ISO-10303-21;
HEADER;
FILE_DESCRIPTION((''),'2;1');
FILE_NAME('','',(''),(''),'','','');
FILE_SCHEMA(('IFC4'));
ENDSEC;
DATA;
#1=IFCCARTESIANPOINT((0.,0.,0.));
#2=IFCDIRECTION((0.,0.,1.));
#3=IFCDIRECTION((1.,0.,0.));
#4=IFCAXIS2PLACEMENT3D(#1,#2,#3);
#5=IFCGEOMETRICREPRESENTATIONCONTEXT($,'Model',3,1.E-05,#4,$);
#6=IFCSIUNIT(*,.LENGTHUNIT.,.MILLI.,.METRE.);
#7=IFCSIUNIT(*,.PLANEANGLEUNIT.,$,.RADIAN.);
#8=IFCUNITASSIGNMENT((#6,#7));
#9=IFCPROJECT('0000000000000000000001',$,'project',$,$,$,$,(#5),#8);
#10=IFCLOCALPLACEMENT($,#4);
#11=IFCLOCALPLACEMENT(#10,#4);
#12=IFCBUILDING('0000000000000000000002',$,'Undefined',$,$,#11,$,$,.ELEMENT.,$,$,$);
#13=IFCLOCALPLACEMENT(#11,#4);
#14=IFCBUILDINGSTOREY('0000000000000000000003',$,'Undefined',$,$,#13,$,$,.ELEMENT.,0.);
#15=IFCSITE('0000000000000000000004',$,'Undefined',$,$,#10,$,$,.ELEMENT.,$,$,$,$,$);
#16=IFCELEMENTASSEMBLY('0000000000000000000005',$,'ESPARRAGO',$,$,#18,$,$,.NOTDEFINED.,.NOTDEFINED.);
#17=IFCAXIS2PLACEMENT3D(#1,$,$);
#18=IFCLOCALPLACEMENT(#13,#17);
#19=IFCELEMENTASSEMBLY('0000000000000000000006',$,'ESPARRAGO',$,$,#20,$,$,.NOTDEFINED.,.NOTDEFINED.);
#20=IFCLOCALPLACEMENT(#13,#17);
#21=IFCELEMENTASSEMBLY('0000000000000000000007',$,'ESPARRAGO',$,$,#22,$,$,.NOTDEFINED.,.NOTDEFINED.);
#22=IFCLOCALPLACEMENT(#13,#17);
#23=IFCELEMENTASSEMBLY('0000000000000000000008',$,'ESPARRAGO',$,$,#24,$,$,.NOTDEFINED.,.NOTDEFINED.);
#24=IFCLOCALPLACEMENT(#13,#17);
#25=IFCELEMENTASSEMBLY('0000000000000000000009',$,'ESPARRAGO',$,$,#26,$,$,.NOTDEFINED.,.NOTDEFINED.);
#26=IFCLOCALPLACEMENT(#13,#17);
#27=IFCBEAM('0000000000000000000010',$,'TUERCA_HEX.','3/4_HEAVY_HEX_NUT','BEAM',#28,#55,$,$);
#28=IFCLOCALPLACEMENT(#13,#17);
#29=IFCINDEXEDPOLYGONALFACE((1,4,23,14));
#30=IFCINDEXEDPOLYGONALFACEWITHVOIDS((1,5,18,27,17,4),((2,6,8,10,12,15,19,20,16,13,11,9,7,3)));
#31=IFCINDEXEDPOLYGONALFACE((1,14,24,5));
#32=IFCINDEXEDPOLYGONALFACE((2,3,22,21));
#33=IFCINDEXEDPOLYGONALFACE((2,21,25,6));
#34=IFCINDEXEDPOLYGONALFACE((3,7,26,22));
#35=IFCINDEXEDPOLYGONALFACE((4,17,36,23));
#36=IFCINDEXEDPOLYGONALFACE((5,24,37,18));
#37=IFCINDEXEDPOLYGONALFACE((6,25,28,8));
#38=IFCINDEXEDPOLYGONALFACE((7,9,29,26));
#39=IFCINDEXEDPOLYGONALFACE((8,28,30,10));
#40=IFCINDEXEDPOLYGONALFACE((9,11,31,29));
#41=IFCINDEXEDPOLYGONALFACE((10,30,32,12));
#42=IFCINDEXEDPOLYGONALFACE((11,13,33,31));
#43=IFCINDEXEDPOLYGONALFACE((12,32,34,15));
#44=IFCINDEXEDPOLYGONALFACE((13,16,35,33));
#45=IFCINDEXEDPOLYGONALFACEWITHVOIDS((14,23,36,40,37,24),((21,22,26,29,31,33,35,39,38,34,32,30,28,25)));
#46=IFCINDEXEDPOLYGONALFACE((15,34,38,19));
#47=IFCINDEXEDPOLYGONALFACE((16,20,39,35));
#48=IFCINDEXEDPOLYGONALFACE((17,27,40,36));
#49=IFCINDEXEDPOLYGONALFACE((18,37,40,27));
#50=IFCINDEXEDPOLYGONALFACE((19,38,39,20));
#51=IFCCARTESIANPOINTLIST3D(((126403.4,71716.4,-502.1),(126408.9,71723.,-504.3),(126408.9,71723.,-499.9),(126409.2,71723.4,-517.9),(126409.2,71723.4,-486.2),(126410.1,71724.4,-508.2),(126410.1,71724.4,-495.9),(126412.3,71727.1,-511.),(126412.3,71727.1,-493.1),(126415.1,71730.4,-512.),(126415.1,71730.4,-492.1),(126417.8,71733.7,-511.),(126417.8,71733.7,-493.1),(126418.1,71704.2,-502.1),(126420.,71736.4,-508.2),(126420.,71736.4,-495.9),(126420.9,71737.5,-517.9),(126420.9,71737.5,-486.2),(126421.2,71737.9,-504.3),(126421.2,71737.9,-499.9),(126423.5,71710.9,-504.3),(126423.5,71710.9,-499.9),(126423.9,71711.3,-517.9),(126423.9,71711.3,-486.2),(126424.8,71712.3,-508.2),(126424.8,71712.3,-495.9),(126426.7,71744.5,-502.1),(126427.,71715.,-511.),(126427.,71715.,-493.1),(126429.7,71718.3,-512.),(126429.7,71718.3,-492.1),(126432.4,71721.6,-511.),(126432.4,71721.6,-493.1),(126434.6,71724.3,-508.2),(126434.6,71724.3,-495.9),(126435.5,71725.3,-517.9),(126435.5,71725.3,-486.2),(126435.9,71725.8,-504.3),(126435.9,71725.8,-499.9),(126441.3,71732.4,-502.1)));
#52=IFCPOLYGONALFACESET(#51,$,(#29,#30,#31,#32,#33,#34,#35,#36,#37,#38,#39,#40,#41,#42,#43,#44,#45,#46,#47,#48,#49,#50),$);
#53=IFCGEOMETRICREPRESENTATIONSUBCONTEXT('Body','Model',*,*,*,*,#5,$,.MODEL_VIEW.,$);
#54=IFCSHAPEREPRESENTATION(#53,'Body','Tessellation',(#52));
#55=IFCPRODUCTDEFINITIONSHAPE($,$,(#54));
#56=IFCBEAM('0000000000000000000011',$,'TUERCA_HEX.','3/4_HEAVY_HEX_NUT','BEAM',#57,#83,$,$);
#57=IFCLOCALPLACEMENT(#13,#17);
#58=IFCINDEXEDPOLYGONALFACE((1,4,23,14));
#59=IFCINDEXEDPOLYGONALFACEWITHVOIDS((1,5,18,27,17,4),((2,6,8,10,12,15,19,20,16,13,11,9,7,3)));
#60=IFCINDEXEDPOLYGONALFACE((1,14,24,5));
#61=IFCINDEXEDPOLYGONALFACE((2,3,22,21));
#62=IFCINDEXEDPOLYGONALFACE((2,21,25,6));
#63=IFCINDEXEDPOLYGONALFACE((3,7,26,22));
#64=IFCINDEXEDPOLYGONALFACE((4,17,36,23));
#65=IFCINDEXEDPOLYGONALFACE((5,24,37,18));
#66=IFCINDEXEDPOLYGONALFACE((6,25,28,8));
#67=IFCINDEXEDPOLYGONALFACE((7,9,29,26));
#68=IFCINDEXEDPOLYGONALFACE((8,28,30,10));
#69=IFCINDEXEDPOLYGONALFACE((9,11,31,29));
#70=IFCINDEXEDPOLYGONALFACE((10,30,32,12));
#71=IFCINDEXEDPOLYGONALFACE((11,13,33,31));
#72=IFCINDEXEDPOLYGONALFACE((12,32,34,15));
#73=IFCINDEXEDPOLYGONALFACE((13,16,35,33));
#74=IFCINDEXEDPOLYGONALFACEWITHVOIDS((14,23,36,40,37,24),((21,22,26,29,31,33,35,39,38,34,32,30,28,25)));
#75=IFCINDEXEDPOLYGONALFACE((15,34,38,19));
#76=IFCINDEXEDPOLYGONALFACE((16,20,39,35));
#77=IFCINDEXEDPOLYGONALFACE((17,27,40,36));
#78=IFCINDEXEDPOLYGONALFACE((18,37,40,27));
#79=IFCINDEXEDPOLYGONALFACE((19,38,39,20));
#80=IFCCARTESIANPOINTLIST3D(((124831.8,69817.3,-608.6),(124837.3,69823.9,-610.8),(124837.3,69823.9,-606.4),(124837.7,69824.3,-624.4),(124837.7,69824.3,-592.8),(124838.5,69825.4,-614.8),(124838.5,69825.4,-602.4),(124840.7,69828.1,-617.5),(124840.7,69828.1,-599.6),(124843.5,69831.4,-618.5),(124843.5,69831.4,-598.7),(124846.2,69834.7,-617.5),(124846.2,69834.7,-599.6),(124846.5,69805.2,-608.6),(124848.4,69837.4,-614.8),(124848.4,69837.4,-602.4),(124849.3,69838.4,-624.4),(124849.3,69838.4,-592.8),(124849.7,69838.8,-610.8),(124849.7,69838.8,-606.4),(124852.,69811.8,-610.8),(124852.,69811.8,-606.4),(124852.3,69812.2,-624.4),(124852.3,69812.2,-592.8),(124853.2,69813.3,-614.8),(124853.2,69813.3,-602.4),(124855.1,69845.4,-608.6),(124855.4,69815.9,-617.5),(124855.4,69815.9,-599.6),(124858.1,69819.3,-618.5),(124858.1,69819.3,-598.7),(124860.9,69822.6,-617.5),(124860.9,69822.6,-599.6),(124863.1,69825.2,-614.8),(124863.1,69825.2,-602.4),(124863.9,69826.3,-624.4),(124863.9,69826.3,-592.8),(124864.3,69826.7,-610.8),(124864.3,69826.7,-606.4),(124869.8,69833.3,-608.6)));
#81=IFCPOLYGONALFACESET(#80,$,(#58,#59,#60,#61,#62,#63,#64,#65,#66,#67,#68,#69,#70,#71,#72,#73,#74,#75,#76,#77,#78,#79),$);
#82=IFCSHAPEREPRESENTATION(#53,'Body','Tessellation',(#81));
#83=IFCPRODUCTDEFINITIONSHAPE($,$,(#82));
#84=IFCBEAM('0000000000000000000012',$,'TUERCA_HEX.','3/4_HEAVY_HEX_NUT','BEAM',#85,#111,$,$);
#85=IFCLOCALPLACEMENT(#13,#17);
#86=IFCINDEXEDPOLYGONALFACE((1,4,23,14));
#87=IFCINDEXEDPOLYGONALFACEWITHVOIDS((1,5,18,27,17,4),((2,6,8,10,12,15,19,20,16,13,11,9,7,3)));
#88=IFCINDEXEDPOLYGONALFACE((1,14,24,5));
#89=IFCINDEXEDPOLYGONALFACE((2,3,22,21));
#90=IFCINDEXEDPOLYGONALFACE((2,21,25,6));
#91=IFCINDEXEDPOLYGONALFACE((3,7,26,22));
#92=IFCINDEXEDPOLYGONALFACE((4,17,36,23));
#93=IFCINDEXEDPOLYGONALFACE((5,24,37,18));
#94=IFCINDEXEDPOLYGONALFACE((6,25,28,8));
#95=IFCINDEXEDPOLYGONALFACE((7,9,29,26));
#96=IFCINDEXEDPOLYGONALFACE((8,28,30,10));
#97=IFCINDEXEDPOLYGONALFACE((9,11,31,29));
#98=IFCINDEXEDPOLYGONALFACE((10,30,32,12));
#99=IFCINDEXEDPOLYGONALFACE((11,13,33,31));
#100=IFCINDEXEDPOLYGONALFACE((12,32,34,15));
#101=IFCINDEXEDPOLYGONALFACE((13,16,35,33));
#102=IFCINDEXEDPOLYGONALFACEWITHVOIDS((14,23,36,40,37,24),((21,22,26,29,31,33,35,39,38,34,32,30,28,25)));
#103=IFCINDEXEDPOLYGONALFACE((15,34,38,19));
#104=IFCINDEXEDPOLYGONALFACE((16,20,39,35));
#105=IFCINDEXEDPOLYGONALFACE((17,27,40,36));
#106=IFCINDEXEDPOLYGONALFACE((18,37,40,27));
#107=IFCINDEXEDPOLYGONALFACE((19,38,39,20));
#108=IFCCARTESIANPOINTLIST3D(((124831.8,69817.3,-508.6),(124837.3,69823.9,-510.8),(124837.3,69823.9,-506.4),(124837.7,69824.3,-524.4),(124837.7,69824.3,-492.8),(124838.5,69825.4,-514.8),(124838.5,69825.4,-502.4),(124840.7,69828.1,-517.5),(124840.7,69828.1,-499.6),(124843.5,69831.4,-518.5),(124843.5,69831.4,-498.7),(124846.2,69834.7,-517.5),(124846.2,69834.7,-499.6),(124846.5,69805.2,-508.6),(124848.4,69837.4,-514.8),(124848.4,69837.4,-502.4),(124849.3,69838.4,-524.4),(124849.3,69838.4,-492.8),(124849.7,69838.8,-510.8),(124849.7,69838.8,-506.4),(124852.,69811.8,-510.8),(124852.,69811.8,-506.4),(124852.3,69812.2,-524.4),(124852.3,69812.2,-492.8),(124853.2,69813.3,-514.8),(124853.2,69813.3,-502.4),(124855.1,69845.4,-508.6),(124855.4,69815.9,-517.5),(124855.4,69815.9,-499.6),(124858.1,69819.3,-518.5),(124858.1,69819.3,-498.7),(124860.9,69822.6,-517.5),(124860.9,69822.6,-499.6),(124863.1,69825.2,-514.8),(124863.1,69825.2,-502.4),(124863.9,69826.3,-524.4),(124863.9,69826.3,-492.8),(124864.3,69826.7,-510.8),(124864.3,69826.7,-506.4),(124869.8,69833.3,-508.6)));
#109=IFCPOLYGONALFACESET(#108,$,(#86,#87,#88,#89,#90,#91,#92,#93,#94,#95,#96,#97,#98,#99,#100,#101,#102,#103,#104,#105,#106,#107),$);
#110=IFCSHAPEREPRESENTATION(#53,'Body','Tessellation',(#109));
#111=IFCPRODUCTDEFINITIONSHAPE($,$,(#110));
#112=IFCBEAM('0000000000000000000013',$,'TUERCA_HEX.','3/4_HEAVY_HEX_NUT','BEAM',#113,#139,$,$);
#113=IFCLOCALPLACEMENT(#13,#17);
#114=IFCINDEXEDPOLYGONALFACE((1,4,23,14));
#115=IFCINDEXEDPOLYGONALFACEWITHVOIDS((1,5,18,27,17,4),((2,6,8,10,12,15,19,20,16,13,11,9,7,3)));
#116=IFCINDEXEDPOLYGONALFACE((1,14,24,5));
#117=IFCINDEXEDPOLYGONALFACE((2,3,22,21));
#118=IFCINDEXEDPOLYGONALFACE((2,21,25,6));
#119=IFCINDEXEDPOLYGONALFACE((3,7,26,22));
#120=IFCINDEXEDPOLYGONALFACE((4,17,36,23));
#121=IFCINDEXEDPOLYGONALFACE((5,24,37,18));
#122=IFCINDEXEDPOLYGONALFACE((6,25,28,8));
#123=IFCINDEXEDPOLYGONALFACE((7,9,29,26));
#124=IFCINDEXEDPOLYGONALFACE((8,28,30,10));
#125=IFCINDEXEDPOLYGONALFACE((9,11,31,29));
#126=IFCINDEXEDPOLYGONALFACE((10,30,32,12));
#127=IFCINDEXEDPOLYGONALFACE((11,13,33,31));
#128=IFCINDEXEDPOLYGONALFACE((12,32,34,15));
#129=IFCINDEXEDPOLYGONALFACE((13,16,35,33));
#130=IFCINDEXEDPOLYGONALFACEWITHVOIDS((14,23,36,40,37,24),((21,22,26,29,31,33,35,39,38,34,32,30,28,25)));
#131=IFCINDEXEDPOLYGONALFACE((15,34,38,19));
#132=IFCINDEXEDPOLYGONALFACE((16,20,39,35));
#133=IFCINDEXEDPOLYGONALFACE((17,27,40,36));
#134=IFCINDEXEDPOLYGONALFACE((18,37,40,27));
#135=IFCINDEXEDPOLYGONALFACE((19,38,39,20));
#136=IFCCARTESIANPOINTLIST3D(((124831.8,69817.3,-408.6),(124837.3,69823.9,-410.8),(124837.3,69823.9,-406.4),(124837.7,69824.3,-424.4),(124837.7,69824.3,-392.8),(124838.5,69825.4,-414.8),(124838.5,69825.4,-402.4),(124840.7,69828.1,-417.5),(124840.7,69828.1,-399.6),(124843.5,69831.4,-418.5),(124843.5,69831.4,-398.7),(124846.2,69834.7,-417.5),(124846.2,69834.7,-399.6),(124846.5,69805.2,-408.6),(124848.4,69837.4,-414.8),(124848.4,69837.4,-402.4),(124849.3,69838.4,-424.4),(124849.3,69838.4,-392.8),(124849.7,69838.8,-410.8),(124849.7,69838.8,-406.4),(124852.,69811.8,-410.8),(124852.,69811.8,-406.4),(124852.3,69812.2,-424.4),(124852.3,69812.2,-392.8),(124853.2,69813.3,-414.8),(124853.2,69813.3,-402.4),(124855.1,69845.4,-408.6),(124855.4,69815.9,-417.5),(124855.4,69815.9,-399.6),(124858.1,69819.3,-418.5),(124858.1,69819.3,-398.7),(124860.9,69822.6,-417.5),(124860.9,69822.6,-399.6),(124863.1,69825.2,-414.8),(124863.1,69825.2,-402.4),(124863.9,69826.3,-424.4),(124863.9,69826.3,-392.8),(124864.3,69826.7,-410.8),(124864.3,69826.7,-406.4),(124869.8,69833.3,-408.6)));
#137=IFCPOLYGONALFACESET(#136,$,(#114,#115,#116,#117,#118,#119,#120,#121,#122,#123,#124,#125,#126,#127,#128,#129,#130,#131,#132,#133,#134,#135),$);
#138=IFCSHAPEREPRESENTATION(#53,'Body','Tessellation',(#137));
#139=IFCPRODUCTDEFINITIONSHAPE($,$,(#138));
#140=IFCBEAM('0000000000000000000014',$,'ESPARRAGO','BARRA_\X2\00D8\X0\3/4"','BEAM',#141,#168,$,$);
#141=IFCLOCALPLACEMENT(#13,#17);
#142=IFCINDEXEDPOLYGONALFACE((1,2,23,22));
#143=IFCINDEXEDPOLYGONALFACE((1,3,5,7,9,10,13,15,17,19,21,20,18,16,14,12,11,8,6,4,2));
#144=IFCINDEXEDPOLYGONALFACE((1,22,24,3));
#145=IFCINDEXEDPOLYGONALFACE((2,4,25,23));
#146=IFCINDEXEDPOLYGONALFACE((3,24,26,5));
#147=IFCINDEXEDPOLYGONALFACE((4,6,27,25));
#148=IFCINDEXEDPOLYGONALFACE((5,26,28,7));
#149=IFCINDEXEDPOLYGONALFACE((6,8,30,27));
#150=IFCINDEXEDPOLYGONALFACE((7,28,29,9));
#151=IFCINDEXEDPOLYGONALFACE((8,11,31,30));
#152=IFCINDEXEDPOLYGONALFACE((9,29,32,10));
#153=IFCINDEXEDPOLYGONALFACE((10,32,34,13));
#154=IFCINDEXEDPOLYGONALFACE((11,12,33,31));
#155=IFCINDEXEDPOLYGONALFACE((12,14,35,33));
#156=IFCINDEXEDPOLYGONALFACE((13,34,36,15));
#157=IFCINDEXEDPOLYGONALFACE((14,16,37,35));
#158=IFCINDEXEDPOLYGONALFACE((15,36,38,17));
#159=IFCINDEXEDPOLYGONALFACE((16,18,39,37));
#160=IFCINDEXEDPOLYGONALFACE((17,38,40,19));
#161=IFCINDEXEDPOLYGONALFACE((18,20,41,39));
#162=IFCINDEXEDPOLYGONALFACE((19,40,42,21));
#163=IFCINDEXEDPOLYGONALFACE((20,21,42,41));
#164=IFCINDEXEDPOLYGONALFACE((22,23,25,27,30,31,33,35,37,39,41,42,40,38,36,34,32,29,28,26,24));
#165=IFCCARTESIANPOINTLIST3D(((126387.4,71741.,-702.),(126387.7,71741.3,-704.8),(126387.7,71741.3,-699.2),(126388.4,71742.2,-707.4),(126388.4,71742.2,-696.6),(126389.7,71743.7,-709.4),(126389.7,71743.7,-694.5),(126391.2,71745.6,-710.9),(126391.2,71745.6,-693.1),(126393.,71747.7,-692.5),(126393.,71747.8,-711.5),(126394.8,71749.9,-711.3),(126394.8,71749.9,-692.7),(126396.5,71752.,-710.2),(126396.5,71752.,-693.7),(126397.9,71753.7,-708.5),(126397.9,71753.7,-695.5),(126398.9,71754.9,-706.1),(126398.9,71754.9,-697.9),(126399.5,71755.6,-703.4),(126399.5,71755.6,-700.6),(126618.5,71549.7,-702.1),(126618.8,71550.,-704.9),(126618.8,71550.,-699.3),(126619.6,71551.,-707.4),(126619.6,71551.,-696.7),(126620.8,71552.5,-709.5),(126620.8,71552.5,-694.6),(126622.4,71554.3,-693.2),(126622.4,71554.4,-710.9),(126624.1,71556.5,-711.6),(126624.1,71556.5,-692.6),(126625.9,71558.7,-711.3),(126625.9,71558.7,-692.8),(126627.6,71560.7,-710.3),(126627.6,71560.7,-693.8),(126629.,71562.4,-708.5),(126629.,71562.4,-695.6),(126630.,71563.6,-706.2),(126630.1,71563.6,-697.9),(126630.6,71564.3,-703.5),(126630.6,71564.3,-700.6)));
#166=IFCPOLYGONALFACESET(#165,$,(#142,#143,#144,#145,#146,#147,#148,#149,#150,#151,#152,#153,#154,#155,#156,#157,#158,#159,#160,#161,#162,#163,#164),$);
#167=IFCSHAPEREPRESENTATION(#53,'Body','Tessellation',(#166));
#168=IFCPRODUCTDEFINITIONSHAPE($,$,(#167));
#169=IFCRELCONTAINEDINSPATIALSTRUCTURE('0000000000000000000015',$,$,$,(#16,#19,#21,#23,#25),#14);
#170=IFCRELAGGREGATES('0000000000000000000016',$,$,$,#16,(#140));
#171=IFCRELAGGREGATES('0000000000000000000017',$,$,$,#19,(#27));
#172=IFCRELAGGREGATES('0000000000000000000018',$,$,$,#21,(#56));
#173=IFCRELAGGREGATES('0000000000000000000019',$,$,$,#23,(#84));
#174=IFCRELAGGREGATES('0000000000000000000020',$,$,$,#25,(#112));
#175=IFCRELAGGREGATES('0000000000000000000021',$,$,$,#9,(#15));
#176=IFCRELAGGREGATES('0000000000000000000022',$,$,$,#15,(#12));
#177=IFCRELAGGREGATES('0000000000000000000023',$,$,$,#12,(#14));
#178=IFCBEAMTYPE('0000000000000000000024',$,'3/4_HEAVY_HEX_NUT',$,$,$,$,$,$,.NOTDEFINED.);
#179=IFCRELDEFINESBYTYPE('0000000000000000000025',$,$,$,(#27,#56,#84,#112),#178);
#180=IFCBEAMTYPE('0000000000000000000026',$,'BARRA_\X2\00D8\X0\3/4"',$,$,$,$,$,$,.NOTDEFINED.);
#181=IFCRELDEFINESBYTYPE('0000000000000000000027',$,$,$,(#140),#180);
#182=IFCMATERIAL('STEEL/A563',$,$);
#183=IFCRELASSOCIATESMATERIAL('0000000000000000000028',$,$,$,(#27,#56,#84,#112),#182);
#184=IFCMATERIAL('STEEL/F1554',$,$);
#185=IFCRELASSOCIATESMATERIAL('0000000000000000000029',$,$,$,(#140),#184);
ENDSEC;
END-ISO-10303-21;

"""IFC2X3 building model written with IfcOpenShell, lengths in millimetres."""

from ifc_helpers import new_model, si_unit, frame, origin_with_axes, origin_2d_with_axis, place, context, subcontext, project, spatial, polyline, circle, outline, extrude, material, type_object, element, aggregate, save


model = new_model("IFC2X3")

# Units and contexts
model_context = context("Model", 3, precision=1e-05, world=origin_with_axes())
body_context = subcontext(model_context, "Body", "Model", "MODEL_VIEW")
ifc_project = project(units=[si_unit("LENGTHUNIT", "METRE", prefix="MILLI"), si_unit("PLANEANGLEUNIT", "RADIAN")], contexts=[model_context])

# Site, building, storey
site_placement = place(None, origin_with_axes())
site = spatial("IfcSite", under=ifc_project, at=site_placement, Name="Undefined", CompositionType="ELEMENT")
building_placement = place(site_placement, origin_with_axes())
building = spatial("IfcBuilding", under=site, at=building_placement, Name="Undefined", CompositionType="ELEMENT")
storey_placement = place(building_placement, origin_with_axes())
storey = spatial("IfcBuildingStorey", under=building, at=storey_placement, Name="Undefined", CompositionType="ELEMENT", Elevation=0.0)

# Element assemblies
assembly_1_placement = place(storey_placement, origin_with_axes())
assembly_1 = element("IfcElementAssembly", 1, at=assembly_1_placement, inside=storey, Name="ESPARRAGO", AssemblyPlace="NOTDEFINED", PredefinedType="NOTDEFINED")
assembly_2_placement = place(storey_placement, origin_with_axes())
assembly_2 = element("IfcElementAssembly", 2, at=assembly_2_placement, inside=storey, Name="ESPARRAGO", AssemblyPlace="NOTDEFINED", PredefinedType="NOTDEFINED")
assembly_3_placement = place(storey_placement, origin_with_axes())
assembly_3 = element("IfcElementAssembly", 3, at=assembly_3_placement, inside=storey, Name="ESPARRAGO", AssemblyPlace="NOTDEFINED", PredefinedType="NOTDEFINED")
assembly_4_placement = place(storey_placement, origin_with_axes())
assembly_4 = element("IfcElementAssembly", 4, at=assembly_4_placement, inside=storey, Name="ESPARRAGO", AssemblyPlace="NOTDEFINED", PredefinedType="NOTDEFINED")
assembly_5_placement = place(storey_placement, origin_with_axes())
assembly_5 = element("IfcElementAssembly", 5, at=assembly_5_placement, inside=storey, Name="ESPARRAGO", AssemblyPlace="NOTDEFINED", PredefinedType="NOTDEFINED")

# Beams
ifc_material_1 = material(Name="STEEL/A563")
beam_type_1 = type_object("IfcBeamType", Name="3/4_HEAVY_HEX_NUT", PredefinedType="NOTDEFINED")
beam_1_placement = place(assembly_2_placement, frame((126415.1, 71730.4, -502.1), z_axis=(0.000012, -0.00001, 1.0), x_axis=(0.7704, -0.637561, -0.000016)))
beam_1 = element("IfcBeam", 6, at=beam_1_placement, type_object=beam_type_1, material=ifc_material_1, Name="TUERCA_HEX.", Description="3/4_HEAVY_HEX_NUT", ObjectType="BEAM", context=body_context, shape_type="SweptSolid", body=[
    extrude(outline(polyline([(9.1, -15.8), (-9.1, -15.8), (-18.3, 0.0), (-9.1, 15.8), (9.1, 15.8), (18.3, 0.0), (9.1, -15.8)]), holes=[polyline([(-4.3, 8.9), (-7.8, 6.2), (-9.7, 2.2), (-9.7, -2.2), (-7.8, -6.2), (-4.3, -8.9), (0.0, -9.9), (4.3, -8.9), (7.8, -6.2), (9.7, -2.2), (9.7, 2.2), (7.8, 6.2), (4.3, 8.9), (0.0, 9.9), (-4.3, 8.9)])]), frame((19.0, 0.0, 0.0), z_axis=(-1.0, 0.0, 0.0), x_axis=(0.0, -1.0, 0.0)), (0.0, 0.0, 1.0), 19.0),
])
beam_2_placement = place(assembly_3_placement, frame((124843.5, 69831.4, -608.6), z_axis=(0.000012, -0.00001, 1.0), x_axis=(0.7704, -0.637561, -0.000016)))
beam_2 = element("IfcBeam", 7, at=beam_2_placement, type_object=beam_type_1, material=ifc_material_1, Name="TUERCA_HEX.", Description="3/4_HEAVY_HEX_NUT", ObjectType="BEAM", context=body_context, shape_type="SweptSolid", body=[
    extrude(outline(polyline([(9.1, -15.8), (-9.1, -15.8), (-18.3, 0.0), (-9.1, 15.8), (9.1, 15.8), (18.3, 0.0), (9.1, -15.8)]), holes=[polyline([(-4.3, 8.9), (-7.8, 6.2), (-9.7, 2.2), (-9.7, -2.2), (-7.8, -6.2), (-4.3, -8.9), (0.0, -9.9), (4.3, -8.9), (7.8, -6.2), (9.7, -2.2), (9.7, 2.2), (7.8, 6.2), (4.3, 8.9), (0.0, 9.9), (-4.3, 8.9)])]), frame((19.0, 0.0, 0.0), z_axis=(-1.0, 0.0, 0.0), x_axis=(0.0, -1.0, 0.0)), (0.0, 0.0, 1.0), 19.0),
])
beam_3_placement = place(assembly_4_placement, frame((124843.5, 69831.4, -508.6), z_axis=(0.000012, -0.00001, 1.0), x_axis=(0.7704, -0.637561, -0.000016)))
beam_3 = element("IfcBeam", 8, at=beam_3_placement, type_object=beam_type_1, material=ifc_material_1, Name="TUERCA_HEX.", Description="3/4_HEAVY_HEX_NUT", ObjectType="BEAM", context=body_context, shape_type="SweptSolid", body=[
    extrude(outline(polyline([(9.1, -15.8), (-9.1, -15.8), (-18.3, 0.0), (-9.1, 15.8), (9.1, 15.8), (18.3, 0.0), (9.1, -15.8)]), holes=[polyline([(-4.3, 8.9), (-7.8, 6.2), (-9.7, 2.2), (-9.7, -2.2), (-7.8, -6.2), (-4.3, -8.9), (0.0, -9.9), (4.3, -8.9), (7.8, -6.2), (9.7, -2.2), (9.7, 2.2), (7.8, 6.2), (4.3, 8.9), (0.0, 9.9), (-4.3, 8.9)])]), frame((19.0, 0.0, 0.0), z_axis=(-1.0, 0.0, 0.0), x_axis=(0.0, -1.0, 0.0)), (0.0, 0.0, 1.0), 19.0),
])
beam_4_placement = place(assembly_5_placement, frame((124843.5, 69831.4, -408.6), z_axis=(0.000012, -0.00001, 1.0), x_axis=(0.7704, -0.637561, -0.000016)))
beam_4 = element("IfcBeam", 9, at=beam_4_placement, type_object=beam_type_1, material=ifc_material_1, Name="TUERCA_HEX.", Description="3/4_HEAVY_HEX_NUT", ObjectType="BEAM", context=body_context, shape_type="SweptSolid", body=[
    extrude(outline(polyline([(9.1, -15.8), (-9.1, -15.8), (-18.3, 0.0), (-9.1, 15.8), (9.1, 15.8), (18.3, 0.0), (9.1, -15.8)]), holes=[polyline([(-4.3, 8.9), (-7.8, 6.2), (-9.7, 2.2), (-9.7, -2.2), (-7.8, -6.2), (-4.3, -8.9), (0.0, -9.9), (4.3, -8.9), (7.8, -6.2), (9.7, -2.2), (9.7, 2.2), (7.8, 6.2), (4.3, 8.9), (0.0, 9.9), (-4.3, 8.9)])]), frame((19.0, 0.0, 0.0), z_axis=(-1.0, 0.0, 0.0), x_axis=(0.0, -1.0, 0.0)), (0.0, 0.0, 1.0), 19.0),
])
ifc_material_2 = material(Name="STEEL/F1554")
beam_type_2 = type_object("IfcBeamType", Name="BARRA_Ø3/4\"", PredefinedType="NOTDEFINED")
beam_5_placement = place(assembly_1_placement, frame((126393.5, 71748.3, -702.0), z_axis=(0.000162, -0.000134, 1.0), x_axis=(0.770403, -0.637558, -0.000211)))
beam_5 = element("IfcBeam", 10, at=beam_5_placement, type_object=beam_type_2, material=ifc_material_2, Name="ESPARRAGO", Description="BARRA_Ø3/4\"", ObjectType="BEAM", context=body_context, shape_type="SweptSolid", body=[
    extrude(circle(Radius=9.5, at=origin_2d_with_axis()), frame((300.0, 0.0, 0.0), z_axis=(-1.0, 0.0, 0.0), x_axis=(0.0, -1.0, 0.0)), (0.0, 0.0, 1.0), 300.0),
])
aggregate(assembly_1, [beam_5])
aggregate(assembly_2, [beam_1])
aggregate(assembly_3, [beam_2])
aggregate(assembly_4, [beam_3])
aggregate(assembly_5, [beam_4])

save(model, "model.ifc")
